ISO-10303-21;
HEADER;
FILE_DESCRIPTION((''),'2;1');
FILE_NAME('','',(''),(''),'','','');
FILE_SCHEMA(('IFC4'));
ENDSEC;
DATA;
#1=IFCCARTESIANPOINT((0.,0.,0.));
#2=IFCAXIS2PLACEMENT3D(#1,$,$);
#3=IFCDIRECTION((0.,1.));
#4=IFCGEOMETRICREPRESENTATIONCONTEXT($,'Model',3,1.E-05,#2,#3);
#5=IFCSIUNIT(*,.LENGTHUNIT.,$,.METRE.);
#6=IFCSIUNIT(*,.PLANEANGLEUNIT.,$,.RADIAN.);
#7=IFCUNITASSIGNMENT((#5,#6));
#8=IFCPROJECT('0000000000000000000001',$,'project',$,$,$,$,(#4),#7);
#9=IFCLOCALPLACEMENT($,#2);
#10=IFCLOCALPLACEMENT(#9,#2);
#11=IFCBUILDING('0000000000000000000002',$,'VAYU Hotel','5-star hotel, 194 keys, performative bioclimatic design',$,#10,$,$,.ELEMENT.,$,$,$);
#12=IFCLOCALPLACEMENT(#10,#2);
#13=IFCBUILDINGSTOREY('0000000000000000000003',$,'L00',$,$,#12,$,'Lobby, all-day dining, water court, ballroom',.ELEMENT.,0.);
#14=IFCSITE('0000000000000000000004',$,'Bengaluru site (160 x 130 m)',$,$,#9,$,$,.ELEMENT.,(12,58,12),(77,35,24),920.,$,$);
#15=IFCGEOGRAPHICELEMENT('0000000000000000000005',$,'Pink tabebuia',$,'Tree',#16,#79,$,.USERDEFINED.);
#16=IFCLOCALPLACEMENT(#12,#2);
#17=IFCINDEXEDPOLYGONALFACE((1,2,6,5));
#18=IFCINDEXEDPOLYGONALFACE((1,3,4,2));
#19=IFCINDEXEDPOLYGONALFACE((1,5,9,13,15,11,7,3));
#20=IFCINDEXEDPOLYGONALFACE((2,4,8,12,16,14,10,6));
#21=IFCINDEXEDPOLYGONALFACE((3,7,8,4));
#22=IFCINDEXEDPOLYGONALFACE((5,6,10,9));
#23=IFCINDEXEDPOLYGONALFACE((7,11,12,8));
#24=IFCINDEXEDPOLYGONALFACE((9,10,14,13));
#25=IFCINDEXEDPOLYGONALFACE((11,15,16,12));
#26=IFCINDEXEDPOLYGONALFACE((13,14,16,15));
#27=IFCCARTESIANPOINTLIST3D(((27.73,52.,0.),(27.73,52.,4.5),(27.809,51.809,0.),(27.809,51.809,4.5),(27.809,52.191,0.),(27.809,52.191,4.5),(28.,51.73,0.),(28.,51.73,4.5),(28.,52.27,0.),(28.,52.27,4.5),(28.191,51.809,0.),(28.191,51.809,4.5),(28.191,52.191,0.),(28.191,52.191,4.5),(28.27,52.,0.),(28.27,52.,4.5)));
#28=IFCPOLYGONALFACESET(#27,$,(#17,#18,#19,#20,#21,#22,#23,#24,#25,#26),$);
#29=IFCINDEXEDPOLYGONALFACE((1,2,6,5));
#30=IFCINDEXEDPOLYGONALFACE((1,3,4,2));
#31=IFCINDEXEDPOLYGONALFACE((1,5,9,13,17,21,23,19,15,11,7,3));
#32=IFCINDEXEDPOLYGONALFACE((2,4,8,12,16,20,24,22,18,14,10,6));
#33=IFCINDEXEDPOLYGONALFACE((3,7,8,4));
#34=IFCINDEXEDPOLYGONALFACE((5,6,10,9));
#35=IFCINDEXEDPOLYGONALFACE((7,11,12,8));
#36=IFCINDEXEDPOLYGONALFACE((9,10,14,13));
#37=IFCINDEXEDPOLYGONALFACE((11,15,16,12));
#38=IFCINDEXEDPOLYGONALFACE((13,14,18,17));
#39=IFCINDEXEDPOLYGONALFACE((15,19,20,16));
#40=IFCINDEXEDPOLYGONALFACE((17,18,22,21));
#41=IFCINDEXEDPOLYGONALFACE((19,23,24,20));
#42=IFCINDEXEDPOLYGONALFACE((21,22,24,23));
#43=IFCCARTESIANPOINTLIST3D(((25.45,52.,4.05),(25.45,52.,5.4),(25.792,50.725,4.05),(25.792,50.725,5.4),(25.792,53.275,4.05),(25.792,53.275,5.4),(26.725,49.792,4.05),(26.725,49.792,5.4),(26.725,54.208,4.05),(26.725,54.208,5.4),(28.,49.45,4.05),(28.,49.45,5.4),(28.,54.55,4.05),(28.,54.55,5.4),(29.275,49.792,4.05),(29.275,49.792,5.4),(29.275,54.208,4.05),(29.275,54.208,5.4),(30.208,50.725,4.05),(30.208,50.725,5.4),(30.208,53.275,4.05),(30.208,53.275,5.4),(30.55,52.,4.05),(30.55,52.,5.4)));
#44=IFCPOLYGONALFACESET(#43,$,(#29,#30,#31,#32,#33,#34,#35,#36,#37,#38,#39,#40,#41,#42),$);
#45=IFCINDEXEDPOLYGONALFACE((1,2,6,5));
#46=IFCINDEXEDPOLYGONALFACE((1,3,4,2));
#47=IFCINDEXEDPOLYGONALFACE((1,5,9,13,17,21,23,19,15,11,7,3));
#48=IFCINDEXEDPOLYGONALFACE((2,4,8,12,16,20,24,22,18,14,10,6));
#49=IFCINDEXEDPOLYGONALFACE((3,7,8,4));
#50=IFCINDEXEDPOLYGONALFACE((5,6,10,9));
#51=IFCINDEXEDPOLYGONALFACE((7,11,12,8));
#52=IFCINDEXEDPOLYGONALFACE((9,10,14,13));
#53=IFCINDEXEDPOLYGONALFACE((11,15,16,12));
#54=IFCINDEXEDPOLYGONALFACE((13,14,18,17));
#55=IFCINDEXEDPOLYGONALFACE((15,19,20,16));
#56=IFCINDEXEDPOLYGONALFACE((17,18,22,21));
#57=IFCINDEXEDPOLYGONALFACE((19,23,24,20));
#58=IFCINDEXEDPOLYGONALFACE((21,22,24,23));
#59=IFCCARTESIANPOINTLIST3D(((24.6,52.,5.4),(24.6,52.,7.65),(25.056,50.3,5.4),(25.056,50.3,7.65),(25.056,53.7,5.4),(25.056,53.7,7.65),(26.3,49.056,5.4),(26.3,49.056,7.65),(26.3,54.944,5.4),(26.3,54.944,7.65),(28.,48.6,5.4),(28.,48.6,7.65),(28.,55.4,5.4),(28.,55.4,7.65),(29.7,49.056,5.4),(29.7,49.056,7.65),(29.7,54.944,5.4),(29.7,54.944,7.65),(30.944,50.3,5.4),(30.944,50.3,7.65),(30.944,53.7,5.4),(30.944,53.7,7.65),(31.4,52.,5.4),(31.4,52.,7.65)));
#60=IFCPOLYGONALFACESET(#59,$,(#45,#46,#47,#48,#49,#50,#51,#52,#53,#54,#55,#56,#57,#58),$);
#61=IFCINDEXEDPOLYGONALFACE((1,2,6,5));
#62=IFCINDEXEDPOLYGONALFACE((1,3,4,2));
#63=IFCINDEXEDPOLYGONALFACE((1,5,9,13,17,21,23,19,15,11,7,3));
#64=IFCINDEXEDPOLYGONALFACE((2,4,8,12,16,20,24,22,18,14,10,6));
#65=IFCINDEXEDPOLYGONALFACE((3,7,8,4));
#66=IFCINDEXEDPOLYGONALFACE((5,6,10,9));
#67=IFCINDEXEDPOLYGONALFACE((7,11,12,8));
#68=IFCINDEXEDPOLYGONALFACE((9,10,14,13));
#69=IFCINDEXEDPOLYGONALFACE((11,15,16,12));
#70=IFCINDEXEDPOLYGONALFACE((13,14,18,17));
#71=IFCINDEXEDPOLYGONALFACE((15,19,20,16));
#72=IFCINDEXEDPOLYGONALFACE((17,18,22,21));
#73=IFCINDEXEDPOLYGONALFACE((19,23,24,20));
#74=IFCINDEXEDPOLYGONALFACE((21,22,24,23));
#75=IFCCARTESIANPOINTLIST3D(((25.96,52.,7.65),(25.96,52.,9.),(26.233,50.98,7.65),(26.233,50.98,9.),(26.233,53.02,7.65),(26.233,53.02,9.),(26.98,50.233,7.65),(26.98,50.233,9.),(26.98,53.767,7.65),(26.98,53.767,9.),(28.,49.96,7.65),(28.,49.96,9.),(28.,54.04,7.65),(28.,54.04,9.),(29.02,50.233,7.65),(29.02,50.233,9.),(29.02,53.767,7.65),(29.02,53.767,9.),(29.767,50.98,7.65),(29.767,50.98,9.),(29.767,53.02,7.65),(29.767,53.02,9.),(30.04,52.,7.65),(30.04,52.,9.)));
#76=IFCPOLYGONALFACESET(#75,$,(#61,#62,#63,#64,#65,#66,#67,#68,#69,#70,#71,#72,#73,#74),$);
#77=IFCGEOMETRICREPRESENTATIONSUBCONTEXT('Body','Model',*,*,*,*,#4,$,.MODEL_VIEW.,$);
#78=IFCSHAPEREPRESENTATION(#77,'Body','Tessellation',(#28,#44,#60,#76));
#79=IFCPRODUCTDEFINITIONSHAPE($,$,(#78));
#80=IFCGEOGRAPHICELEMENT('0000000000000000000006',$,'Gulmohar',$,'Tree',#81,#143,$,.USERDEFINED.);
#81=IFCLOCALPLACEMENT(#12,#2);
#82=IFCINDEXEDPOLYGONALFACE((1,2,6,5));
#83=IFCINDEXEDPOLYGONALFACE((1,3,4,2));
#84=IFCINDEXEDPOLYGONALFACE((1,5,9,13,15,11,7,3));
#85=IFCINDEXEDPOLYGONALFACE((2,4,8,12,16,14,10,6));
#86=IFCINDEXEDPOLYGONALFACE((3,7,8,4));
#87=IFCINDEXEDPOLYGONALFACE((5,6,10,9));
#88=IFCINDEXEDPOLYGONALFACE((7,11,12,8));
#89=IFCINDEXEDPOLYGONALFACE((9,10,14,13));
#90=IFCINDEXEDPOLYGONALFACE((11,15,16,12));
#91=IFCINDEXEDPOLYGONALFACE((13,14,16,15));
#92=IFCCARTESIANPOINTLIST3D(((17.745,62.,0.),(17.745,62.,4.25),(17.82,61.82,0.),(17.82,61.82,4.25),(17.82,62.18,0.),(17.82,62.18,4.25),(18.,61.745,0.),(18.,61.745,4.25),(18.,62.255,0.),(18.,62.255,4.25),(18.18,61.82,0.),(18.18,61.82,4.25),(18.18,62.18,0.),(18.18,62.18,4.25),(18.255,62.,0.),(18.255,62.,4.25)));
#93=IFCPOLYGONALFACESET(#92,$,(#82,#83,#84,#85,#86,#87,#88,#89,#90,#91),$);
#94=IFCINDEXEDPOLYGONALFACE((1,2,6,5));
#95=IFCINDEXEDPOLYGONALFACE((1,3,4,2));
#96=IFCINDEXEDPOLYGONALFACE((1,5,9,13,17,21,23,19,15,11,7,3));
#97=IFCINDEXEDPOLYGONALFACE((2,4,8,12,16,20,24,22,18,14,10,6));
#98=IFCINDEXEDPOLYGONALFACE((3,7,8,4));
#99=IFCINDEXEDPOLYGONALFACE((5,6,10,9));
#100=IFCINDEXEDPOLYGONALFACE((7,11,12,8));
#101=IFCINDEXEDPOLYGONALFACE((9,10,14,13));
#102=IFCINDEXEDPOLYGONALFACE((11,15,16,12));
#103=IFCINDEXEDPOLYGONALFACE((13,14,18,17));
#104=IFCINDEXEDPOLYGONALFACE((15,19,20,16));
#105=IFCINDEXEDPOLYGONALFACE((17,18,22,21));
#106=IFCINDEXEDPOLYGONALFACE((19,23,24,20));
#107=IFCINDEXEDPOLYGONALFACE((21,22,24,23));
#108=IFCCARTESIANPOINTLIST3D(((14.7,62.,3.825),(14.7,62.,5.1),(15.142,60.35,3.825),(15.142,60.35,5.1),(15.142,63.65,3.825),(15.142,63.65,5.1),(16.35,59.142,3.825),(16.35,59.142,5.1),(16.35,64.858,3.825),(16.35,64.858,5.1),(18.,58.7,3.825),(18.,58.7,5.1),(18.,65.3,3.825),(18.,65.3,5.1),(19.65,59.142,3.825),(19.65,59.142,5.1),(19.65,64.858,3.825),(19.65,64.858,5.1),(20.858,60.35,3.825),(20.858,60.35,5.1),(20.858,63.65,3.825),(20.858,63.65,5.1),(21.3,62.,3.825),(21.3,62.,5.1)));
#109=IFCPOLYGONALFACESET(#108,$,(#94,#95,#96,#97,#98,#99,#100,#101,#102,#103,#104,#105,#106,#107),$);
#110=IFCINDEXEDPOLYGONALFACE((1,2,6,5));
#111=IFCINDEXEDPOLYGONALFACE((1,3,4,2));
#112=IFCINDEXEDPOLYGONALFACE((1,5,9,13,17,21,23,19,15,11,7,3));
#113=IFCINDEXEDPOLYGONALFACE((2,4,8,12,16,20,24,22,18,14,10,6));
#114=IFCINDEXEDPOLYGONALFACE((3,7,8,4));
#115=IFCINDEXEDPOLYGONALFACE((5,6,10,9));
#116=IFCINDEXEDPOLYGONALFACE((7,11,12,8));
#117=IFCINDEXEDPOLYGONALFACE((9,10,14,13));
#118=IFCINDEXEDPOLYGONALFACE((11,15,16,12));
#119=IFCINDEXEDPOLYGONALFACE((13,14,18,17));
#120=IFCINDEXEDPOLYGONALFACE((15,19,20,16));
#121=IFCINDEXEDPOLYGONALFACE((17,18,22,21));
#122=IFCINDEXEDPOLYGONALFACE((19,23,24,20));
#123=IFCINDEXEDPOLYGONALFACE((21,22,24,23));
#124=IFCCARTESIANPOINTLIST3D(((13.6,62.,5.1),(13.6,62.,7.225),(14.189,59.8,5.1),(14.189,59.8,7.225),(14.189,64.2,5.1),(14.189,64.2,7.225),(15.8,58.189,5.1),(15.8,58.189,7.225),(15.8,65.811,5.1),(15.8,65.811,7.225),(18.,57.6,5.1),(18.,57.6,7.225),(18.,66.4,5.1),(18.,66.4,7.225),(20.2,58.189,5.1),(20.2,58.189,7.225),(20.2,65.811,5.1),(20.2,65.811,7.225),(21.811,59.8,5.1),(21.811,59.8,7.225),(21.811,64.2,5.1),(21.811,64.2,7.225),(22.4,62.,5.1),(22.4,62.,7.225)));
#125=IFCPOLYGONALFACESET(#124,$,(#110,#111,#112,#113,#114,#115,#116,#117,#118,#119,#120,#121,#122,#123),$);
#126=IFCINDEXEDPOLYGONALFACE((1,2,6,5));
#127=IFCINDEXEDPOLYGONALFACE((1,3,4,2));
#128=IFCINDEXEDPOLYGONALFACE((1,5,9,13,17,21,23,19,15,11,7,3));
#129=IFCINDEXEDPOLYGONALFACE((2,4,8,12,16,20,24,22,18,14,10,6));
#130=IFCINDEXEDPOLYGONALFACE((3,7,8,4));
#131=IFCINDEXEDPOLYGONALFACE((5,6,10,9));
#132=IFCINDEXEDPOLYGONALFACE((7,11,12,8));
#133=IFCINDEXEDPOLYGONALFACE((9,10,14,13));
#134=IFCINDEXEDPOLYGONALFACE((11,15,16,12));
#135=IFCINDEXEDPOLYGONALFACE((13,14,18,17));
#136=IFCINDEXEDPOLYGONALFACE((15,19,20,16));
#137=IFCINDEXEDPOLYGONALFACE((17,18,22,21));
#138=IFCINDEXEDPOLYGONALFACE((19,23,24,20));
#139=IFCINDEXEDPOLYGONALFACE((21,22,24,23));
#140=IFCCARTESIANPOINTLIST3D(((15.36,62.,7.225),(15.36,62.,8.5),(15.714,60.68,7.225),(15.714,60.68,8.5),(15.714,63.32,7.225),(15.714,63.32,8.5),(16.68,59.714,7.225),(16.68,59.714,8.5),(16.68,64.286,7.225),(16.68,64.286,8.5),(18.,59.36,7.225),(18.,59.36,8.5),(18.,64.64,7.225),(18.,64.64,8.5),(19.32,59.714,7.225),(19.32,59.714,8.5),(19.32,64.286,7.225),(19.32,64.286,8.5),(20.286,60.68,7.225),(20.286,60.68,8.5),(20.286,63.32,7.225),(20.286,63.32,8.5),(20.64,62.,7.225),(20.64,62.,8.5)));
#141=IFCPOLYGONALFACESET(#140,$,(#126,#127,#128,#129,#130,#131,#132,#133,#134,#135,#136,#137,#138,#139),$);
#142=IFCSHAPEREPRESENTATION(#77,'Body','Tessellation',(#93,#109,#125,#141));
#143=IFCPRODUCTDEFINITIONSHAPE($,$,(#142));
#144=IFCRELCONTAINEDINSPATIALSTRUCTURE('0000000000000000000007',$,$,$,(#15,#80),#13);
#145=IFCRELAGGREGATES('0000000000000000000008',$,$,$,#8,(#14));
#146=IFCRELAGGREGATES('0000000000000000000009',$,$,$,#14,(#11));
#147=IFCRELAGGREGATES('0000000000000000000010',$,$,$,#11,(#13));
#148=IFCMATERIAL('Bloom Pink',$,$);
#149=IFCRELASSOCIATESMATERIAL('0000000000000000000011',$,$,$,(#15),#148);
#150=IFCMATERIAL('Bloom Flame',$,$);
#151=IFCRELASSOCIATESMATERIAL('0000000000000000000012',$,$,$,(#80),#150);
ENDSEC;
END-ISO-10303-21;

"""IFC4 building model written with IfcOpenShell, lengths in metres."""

from ifc_helpers import new_model, si_unit, direction, frame, origin, place, context, subcontext, project, spatial, polyline, outline, extrude, material, element, save


model = new_model("IFC4")

# Units and contexts
model_context = context("Model", 3, precision=1e-05, world=origin(), true_north=direction((0.0, 1.0)))
body_context = subcontext(model_context, "Body", "Model", "MODEL_VIEW")
ifc_project = project(units=[si_unit("LENGTHUNIT", "METRE"), si_unit("PLANEANGLEUNIT", "RADIAN")], contexts=[model_context])

# Site, building, storey
site_placement = place(None, origin())
site = spatial("IfcSite", under=ifc_project, at=site_placement, Name="Bengaluru site (160 x 130 m)", CompositionType="ELEMENT", RefLatitude=(12, 58, 12), RefLongitude=(77, 35, 24), RefElevation=920.0)
building_placement = place(site_placement, origin())
building = spatial("IfcBuilding", under=site, at=building_placement, Name="VAYU Hotel", Description="5-star hotel, 194 keys, performative bioclimatic design", CompositionType="ELEMENT")
storey_placement = place(building_placement, origin())
storey = spatial("IfcBuildingStorey", under=building, at=storey_placement, Name="L00", LongName="Lobby, all-day dining, water court, ballroom", CompositionType="ELEMENT", Elevation=0.0)

# Geographic elements
ifc_material_1 = material(Name="Bloom Pink")
ifc_material_2 = material(Name="Bloom Flame")
geographic_element_1_placement = place(storey_placement, origin())
element("IfcGeographicElement", 1, at=geographic_element_1_placement, inside=storey, material=ifc_material_1, Name="Pink tabebuia", ObjectType="Tree", PredefinedType="USERDEFINED", context=body_context, shape_type="SweptSolid", body=[
    extrude(outline(polyline([(28.27, 52.0), (28.191, 52.191), (28.0, 52.27), (27.809, 52.191), (27.73, 52.0), (27.809, 51.809), (28.0, 51.73), (28.191, 51.809), (28.27, 52.0)])), origin(), (0.0, 0.0, 1.0), 4.5),
    extrude(outline(polyline([(30.55, 52.0), (30.208, 53.275), (29.275, 54.208), (28.0, 54.55), (26.725, 54.208), (25.792, 53.275), (25.45, 52.0), (25.792, 50.725), (26.725, 49.792), (28.0, 49.45), (29.275, 49.792), (30.208, 50.725), (30.55, 52.0)])), frame((0.0, 0.0, 4.05)), (0.0, 0.0, 1.0), 1.35),
    extrude(outline(polyline([(31.4, 52.0), (30.944, 53.7), (29.7, 54.944), (28.0, 55.4), (26.3, 54.944), (25.056, 53.7), (24.6, 52.0), (25.056, 50.3), (26.3, 49.056), (28.0, 48.6), (29.7, 49.056), (30.944, 50.3), (31.4, 52.0)])), frame((0.0, 0.0, 5.4)), (0.0, 0.0, 1.0), 2.25),
    extrude(outline(polyline([(30.04, 52.0), (29.767, 53.02), (29.02, 53.767), (28.0, 54.04), (26.98, 53.767), (26.233, 53.02), (25.96, 52.0), (26.233, 50.98), (26.98, 50.233), (28.0, 49.96), (29.02, 50.233), (29.767, 50.98), (30.04, 52.0)])), frame((0.0, 0.0, 7.65)), (0.0, 0.0, 1.0), 1.35),
])
geographic_element_2_placement = place(storey_placement, origin())
element("IfcGeographicElement", 2, at=geographic_element_2_placement, inside=storey, material=ifc_material_2, Name="Gulmohar", ObjectType="Tree", PredefinedType="USERDEFINED", context=body_context, shape_type="SweptSolid", body=[
    extrude(outline(polyline([(18.255, 62.0), (18.18, 62.18), (18.0, 62.255), (17.82, 62.18), (17.745, 62.0), (17.82, 61.82), (18.0, 61.745), (18.18, 61.82), (18.255, 62.0)])), origin(), (0.0, 0.0, 1.0), 4.25),
    extrude(outline(polyline([(21.3, 62.0), (20.858, 63.65), (19.65, 64.858), (18.0, 65.3), (16.35, 64.858), (15.142, 63.65), (14.7, 62.0), (15.142, 60.35), (16.35, 59.142), (18.0, 58.7), (19.65, 59.142), (20.858, 60.35), (21.3, 62.0)])), frame((0.0, 0.0, 3.825)), (0.0, 0.0, 1.0), 1.275),
    extrude(outline(polyline([(22.4, 62.0), (21.811, 64.2), (20.2, 65.811), (18.0, 66.4), (15.8, 65.811), (14.189, 64.2), (13.6, 62.0), (14.189, 59.8), (15.8, 58.189), (18.0, 57.6), (20.2, 58.189), (21.811, 59.8), (22.4, 62.0)])), frame((0.0, 0.0, 5.1)), (0.0, 0.0, 1.0), 2.125),
    extrude(outline(polyline([(20.64, 62.0), (20.286, 63.32), (19.32, 64.286), (18.0, 64.64), (16.68, 64.286), (15.714, 63.32), (15.36, 62.0), (15.714, 60.68), (16.68, 59.714), (18.0, 59.36), (19.32, 59.714), (20.286, 60.68), (20.64, 62.0)])), frame((0.0, 0.0, 7.225)), (0.0, 0.0, 1.0), 1.275),
])

save(model, "model.ifc")
